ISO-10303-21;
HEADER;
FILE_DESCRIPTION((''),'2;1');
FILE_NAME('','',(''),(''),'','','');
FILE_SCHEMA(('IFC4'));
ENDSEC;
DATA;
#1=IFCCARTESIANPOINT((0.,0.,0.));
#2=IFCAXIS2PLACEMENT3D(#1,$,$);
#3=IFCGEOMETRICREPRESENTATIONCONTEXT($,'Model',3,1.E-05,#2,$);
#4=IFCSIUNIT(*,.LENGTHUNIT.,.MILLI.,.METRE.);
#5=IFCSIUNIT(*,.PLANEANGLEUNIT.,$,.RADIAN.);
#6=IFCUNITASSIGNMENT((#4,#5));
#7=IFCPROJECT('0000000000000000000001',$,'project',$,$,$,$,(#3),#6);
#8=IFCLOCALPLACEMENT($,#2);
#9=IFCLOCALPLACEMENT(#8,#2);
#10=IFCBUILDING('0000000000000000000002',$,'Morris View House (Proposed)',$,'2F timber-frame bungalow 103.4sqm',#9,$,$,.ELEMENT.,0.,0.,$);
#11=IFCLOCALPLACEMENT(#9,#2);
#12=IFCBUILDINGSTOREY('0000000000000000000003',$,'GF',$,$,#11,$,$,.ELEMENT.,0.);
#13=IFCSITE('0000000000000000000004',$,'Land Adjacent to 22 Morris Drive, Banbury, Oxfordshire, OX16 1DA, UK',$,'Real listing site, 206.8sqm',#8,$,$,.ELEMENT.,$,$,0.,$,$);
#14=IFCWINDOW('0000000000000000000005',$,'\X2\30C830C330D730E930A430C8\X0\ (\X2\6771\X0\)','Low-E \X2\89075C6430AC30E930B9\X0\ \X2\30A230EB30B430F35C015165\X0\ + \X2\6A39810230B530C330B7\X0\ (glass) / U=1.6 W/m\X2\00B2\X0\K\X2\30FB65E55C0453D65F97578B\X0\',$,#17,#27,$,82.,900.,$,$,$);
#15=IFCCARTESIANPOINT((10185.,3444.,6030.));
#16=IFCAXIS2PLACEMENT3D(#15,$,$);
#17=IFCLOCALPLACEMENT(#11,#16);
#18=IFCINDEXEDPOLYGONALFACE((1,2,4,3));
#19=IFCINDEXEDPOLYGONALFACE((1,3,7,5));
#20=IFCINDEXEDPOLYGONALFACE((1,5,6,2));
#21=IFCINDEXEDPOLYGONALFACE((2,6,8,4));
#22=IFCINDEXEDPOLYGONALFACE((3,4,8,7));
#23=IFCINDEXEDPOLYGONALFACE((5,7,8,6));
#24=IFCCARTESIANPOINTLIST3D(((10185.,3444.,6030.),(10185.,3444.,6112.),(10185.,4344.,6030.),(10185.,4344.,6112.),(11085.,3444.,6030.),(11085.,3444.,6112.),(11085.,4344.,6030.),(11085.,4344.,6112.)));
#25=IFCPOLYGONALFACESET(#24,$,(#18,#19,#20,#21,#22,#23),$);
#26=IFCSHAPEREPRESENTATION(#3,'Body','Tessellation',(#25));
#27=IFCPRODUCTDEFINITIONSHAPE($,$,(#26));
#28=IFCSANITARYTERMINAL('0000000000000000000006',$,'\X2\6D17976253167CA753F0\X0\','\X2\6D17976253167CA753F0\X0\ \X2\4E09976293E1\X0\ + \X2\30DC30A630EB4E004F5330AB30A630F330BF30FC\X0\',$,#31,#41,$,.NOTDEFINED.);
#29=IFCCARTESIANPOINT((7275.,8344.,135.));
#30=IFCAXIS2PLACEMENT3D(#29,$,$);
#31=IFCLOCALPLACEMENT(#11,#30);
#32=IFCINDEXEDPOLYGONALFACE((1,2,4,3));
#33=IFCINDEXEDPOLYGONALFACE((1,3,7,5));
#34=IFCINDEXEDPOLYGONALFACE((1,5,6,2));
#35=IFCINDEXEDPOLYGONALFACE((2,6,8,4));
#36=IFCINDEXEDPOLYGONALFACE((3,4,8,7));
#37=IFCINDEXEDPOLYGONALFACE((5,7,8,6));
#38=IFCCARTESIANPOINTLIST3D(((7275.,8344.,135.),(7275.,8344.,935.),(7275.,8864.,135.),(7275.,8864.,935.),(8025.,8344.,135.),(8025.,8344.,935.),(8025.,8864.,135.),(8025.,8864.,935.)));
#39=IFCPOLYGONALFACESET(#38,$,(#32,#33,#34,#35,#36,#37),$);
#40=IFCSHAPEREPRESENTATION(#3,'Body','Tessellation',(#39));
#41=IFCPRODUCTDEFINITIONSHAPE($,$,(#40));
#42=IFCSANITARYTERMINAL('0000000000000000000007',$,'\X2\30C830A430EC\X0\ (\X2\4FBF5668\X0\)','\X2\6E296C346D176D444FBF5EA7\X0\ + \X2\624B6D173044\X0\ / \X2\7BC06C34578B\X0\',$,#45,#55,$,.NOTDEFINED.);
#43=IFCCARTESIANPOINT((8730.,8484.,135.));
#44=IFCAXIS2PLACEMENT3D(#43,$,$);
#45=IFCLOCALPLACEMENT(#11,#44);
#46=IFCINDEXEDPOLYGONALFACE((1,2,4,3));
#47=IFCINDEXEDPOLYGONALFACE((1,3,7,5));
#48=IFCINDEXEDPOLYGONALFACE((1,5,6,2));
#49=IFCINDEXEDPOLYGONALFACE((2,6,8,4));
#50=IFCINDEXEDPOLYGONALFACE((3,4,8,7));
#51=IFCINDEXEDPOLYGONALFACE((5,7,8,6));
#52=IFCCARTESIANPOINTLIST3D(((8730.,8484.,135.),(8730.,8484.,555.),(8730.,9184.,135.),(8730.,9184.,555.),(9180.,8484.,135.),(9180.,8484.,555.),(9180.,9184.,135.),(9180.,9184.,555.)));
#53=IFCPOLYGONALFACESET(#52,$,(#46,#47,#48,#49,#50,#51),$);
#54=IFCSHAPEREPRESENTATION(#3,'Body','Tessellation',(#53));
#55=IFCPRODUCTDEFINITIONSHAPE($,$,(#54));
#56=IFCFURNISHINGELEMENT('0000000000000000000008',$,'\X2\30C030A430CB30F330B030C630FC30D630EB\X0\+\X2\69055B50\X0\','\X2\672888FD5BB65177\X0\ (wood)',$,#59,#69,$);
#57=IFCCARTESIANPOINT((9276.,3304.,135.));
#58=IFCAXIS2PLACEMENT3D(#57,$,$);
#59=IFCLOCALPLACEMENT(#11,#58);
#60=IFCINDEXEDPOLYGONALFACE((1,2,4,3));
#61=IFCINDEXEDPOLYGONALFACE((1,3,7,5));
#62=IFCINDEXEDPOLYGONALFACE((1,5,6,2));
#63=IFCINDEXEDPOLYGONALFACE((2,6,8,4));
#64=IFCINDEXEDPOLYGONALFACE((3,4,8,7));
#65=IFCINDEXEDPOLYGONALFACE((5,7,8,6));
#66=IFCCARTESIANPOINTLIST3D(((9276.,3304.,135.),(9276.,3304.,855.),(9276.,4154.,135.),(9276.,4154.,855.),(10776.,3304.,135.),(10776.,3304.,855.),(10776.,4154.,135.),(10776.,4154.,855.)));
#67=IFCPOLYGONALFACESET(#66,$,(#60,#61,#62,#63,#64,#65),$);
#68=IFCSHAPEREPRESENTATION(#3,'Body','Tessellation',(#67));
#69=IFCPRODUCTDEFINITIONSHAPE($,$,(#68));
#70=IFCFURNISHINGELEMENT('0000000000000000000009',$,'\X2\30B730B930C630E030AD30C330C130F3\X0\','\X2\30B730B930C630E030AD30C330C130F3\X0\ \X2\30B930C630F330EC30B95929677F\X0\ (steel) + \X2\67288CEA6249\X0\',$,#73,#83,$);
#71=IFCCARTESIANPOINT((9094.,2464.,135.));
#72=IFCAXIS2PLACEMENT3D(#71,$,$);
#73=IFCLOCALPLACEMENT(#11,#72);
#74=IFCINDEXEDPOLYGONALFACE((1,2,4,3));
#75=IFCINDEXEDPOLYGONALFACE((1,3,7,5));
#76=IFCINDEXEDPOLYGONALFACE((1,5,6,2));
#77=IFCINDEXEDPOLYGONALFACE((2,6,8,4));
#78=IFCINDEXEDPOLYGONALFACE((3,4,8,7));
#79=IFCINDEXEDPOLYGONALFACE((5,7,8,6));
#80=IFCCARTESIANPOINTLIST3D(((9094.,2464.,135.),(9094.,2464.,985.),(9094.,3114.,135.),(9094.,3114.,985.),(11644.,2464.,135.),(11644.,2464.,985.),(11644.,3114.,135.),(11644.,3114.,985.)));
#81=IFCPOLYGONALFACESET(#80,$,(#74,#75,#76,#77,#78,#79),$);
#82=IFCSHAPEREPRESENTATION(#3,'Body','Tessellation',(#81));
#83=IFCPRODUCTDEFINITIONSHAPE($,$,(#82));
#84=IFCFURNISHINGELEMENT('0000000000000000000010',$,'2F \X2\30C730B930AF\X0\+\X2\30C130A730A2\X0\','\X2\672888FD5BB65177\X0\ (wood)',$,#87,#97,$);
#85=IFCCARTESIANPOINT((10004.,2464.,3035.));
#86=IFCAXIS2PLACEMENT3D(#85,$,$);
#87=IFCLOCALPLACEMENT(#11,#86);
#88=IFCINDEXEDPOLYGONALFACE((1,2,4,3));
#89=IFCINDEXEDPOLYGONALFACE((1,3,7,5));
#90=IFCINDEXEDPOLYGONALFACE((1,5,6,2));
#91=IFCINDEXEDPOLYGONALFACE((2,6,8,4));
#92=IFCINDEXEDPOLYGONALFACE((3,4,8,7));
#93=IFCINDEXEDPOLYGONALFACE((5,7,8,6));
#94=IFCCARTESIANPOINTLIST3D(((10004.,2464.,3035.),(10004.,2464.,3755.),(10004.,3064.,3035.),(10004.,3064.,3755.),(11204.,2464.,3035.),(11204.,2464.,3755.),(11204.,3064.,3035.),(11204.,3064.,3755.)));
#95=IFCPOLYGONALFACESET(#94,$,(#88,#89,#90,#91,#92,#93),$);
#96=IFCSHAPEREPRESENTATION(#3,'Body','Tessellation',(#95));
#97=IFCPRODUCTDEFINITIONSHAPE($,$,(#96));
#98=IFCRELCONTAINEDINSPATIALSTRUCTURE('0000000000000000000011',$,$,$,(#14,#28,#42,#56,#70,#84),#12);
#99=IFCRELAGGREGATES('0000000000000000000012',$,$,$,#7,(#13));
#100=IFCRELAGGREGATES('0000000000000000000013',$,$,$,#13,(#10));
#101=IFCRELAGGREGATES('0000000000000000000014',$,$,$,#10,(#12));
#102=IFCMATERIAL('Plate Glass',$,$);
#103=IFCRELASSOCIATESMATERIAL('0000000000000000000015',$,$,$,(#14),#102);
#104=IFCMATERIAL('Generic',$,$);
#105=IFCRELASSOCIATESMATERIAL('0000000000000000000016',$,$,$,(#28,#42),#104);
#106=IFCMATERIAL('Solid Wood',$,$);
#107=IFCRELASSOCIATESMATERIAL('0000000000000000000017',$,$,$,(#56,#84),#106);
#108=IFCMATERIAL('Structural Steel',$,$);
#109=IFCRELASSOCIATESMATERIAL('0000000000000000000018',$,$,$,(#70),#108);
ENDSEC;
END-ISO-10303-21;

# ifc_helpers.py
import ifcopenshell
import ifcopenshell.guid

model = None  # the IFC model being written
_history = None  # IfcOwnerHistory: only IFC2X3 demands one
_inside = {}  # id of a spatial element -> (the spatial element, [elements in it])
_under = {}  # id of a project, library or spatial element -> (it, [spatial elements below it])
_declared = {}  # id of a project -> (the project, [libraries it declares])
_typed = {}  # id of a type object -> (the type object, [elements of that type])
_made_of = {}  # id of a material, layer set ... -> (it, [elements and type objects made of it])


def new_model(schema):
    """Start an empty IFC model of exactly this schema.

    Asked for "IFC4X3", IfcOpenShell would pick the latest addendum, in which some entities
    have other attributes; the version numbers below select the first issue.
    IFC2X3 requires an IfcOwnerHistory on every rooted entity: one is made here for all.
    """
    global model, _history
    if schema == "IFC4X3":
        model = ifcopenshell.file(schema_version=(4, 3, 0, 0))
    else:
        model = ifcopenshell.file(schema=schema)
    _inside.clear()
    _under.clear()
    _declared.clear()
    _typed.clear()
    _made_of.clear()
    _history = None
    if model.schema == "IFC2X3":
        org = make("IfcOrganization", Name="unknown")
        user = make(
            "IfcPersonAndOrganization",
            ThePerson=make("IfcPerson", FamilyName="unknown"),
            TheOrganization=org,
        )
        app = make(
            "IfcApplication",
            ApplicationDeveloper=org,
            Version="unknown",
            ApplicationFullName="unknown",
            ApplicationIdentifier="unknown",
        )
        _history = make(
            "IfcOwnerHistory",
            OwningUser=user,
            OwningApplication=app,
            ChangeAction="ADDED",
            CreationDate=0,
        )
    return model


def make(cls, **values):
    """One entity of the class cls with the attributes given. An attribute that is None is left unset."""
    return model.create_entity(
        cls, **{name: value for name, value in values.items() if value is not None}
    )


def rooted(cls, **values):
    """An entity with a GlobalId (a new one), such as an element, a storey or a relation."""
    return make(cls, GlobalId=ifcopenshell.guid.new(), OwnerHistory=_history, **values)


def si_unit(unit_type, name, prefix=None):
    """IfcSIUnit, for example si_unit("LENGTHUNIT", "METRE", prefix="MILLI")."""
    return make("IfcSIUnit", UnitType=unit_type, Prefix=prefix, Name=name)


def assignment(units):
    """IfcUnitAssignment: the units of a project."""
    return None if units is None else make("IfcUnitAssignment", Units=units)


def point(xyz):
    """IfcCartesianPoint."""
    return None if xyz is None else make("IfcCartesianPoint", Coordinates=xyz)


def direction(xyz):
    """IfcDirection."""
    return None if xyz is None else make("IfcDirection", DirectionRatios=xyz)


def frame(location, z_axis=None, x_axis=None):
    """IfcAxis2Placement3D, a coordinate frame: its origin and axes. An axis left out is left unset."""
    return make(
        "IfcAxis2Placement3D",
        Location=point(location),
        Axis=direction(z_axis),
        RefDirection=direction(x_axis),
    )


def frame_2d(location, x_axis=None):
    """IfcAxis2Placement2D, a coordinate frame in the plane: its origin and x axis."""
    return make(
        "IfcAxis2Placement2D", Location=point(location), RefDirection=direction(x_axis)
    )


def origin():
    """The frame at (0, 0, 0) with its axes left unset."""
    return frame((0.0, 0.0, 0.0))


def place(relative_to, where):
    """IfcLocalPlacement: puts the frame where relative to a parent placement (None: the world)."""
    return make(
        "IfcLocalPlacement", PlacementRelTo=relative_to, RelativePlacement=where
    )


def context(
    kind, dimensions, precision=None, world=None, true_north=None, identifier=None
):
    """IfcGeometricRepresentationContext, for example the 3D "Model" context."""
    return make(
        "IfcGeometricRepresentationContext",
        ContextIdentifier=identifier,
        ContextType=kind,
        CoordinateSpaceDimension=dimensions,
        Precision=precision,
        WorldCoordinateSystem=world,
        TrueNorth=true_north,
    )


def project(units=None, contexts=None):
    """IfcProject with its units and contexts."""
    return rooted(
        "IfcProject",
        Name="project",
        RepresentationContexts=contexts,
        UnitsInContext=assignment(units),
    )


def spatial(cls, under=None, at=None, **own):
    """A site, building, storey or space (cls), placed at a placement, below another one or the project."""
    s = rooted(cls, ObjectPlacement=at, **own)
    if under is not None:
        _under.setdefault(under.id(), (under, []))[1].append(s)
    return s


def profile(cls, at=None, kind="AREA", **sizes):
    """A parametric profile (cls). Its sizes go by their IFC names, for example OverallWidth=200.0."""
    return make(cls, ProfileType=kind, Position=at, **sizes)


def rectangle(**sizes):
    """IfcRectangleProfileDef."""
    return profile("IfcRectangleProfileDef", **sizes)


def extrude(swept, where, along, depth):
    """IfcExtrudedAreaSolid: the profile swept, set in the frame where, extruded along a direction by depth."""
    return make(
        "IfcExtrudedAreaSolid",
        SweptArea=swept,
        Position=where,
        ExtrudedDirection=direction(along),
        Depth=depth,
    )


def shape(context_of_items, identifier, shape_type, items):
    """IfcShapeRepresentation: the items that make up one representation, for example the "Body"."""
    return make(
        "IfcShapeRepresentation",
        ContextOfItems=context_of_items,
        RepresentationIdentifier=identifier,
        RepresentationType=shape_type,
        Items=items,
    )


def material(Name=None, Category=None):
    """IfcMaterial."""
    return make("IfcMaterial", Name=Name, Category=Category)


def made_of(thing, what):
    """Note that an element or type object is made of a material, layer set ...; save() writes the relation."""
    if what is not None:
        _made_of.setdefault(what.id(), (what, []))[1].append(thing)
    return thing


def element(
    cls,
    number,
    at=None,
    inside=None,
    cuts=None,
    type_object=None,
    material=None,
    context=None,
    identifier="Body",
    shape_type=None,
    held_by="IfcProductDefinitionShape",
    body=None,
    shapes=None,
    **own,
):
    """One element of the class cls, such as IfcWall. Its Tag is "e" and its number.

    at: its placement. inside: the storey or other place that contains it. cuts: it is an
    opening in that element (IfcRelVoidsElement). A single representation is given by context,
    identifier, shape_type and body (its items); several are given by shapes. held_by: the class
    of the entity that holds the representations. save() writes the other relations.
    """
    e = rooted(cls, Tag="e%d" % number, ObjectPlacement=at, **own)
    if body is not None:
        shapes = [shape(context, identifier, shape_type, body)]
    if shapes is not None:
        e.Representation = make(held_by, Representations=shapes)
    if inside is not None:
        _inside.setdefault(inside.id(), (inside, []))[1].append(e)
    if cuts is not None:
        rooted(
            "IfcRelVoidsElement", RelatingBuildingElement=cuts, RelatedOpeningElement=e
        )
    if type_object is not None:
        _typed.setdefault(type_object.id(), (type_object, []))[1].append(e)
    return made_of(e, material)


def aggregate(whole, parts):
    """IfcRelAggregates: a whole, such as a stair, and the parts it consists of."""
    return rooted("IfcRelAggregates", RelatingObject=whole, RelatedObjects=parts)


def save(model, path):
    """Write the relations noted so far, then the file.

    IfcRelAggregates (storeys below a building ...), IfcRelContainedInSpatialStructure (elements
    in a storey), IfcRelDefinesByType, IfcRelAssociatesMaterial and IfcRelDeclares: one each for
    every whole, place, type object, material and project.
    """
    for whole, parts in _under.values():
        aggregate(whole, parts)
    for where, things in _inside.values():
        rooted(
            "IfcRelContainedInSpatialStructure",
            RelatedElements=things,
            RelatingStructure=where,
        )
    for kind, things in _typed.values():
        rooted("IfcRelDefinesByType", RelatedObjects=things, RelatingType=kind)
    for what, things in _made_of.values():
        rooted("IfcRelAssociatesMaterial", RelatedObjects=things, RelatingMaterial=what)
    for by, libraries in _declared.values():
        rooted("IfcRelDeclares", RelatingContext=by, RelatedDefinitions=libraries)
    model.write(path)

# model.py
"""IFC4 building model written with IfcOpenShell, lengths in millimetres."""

from ifc_helpers import new_model, si_unit, frame, frame_2d, origin, place, context, project, spatial, rectangle, extrude, material, element, save


model = new_model("IFC4")

# Units and contexts
model_context = context("Model", 3, precision=1e-05, world=origin())
ifc_project = project(units=[si_unit("LENGTHUNIT", "METRE", prefix="MILLI"), si_unit("PLANEANGLEUNIT", "RADIAN")], contexts=[model_context])

# Site, building, storey
site_placement = place(None, origin())
site = spatial("IfcSite", under=ifc_project, at=site_placement, Name="Land Adjacent to 22 Morris Drive, Banbury, Oxfordshire, OX16 1DA, UK", ObjectType="Real listing site, 206.8sqm", CompositionType="ELEMENT", RefElevation=0.0)
building_placement = place(site_placement, origin())
building = spatial("IfcBuilding", under=site, at=building_placement, Name="Morris View House (Proposed)", ObjectType="2F timber-frame bungalow 103.4sqm", CompositionType="ELEMENT", ElevationOfRefHeight=0.0, ElevationOfTerrain=0.0)
storey_placement = place(building_placement, origin())
storey = spatial("IfcBuildingStorey", under=building, at=storey_placement, Name="GF", CompositionType="ELEMENT", Elevation=0.0)

# Shared definitions
ifc_material_1 = material(Name="Solid Wood")

# Shared definitions
ifc_material_2 = material(Name="Plate Glass")

# Window
window_1_placement = place(storey_placement, frame((10185.0, 3444.0, 6030.0)))
element("IfcWindow", 1, at=window_1_placement, inside=storey, material=ifc_material_2, Name="トップライト (東)", Description="Low-E 複層ガラス アルゴン封入 + 樹脂サッシ (glass) / U=1.6 W/m²K・日射取得型", OverallHeight=82.0, OverallWidth=900.0, context=model_context, shape_type="SweptSolid", body=[
    extrude(rectangle(XDim=900.0, YDim=900.0, at=frame_2d((450.0, 450.0))), frame((10185.0, 3444.0, 6030.0)), (0.0, 0.0, 1.0), 82.0),
])

# Sanitary terminals
ifc_material_3 = material(Name="Generic")
sanitary_terminal_1_placement = place(storey_placement, frame((7275.0, 8344.0, 135.0)))
element("IfcSanitaryTerminal", 2, at=sanitary_terminal_1_placement, inside=storey, material=ifc_material_3, Name="洗面化粧台", Description="洗面化粧台 三面鏡 + ボウル一体カウンター", PredefinedType="NOTDEFINED", context=model_context, shape_type="SweptSolid", body=[
    extrude(rectangle(XDim=750.0, YDim=520.0, at=frame_2d((375.0, 260.0))), frame((7275.0, 8344.0, 135.0)), (0.0, 0.0, 1.0), 800.0),
])
sanitary_terminal_2_placement = place(storey_placement, frame((8730.0, 8484.0, 135.0)))
element("IfcSanitaryTerminal", 3, at=sanitary_terminal_2_placement, inside=storey, material=ifc_material_3, Name="トイレ (便器)", Description="温水洗浄便座 + 手洗い / 節水型", PredefinedType="NOTDEFINED", context=model_context, shape_type="SweptSolid", body=[
    extrude(rectangle(XDim=450.0, YDim=700.0, at=frame_2d((225.0, 350.0))), frame((8730.0, 8484.0, 135.0)), (0.0, 0.0, 1.0), 420.0),
])

# Furnishing elements
furnishing_1_placement = place(storey_placement, frame((9276.0, 3304.0, 135.0)))
element("IfcFurnishingElement", 4, at=furnishing_1_placement, inside=storey, material=ifc_material_1, Name="ダイニングテーブル+椅子", Description="木製家具 (wood)", context=model_context, shape_type="SweptSolid", body=[
    extrude(rectangle(XDim=1500.0, YDim=850.0, at=frame_2d((750.0, 425.0))), frame((9276.0, 3304.0, 135.0)), (0.0, 0.0, 1.0), 720.0),
])
ifc_material_4 = material(Name="Structural Steel")
furnishing_2_placement = place(storey_placement, frame((9094.0, 2464.0, 135.0)))
element("IfcFurnishingElement", 5, at=furnishing_2_placement, inside=storey, material=ifc_material_4, Name="システムキッチン", Description="システムキッチン ステンレス天板 (steel) + 木質扉", context=model_context, shape_type="SweptSolid", body=[
    extrude(rectangle(XDim=2550.0, YDim=650.0, at=frame_2d((1275.0, 325.0))), frame((9094.0, 2464.0, 135.0)), (0.0, 0.0, 1.0), 850.0),
])
furnishing_3_placement = place(storey_placement, frame((10004.0, 2464.0, 3035.0)))
element("IfcFurnishingElement", 6, at=furnishing_3_placement, inside=storey, material=ifc_material_1, Name="2F デスク+チェア", Description="木製家具 (wood)", context=model_context, shape_type="SweptSolid", body=[
    extrude(rectangle(XDim=1200.0, YDim=600.0, at=frame_2d((600.0, 300.0))), frame((10004.0, 2464.0, 3035.0)), (0.0, 0.0, 1.0), 720.0),
])

save(model, "model.ifc")
